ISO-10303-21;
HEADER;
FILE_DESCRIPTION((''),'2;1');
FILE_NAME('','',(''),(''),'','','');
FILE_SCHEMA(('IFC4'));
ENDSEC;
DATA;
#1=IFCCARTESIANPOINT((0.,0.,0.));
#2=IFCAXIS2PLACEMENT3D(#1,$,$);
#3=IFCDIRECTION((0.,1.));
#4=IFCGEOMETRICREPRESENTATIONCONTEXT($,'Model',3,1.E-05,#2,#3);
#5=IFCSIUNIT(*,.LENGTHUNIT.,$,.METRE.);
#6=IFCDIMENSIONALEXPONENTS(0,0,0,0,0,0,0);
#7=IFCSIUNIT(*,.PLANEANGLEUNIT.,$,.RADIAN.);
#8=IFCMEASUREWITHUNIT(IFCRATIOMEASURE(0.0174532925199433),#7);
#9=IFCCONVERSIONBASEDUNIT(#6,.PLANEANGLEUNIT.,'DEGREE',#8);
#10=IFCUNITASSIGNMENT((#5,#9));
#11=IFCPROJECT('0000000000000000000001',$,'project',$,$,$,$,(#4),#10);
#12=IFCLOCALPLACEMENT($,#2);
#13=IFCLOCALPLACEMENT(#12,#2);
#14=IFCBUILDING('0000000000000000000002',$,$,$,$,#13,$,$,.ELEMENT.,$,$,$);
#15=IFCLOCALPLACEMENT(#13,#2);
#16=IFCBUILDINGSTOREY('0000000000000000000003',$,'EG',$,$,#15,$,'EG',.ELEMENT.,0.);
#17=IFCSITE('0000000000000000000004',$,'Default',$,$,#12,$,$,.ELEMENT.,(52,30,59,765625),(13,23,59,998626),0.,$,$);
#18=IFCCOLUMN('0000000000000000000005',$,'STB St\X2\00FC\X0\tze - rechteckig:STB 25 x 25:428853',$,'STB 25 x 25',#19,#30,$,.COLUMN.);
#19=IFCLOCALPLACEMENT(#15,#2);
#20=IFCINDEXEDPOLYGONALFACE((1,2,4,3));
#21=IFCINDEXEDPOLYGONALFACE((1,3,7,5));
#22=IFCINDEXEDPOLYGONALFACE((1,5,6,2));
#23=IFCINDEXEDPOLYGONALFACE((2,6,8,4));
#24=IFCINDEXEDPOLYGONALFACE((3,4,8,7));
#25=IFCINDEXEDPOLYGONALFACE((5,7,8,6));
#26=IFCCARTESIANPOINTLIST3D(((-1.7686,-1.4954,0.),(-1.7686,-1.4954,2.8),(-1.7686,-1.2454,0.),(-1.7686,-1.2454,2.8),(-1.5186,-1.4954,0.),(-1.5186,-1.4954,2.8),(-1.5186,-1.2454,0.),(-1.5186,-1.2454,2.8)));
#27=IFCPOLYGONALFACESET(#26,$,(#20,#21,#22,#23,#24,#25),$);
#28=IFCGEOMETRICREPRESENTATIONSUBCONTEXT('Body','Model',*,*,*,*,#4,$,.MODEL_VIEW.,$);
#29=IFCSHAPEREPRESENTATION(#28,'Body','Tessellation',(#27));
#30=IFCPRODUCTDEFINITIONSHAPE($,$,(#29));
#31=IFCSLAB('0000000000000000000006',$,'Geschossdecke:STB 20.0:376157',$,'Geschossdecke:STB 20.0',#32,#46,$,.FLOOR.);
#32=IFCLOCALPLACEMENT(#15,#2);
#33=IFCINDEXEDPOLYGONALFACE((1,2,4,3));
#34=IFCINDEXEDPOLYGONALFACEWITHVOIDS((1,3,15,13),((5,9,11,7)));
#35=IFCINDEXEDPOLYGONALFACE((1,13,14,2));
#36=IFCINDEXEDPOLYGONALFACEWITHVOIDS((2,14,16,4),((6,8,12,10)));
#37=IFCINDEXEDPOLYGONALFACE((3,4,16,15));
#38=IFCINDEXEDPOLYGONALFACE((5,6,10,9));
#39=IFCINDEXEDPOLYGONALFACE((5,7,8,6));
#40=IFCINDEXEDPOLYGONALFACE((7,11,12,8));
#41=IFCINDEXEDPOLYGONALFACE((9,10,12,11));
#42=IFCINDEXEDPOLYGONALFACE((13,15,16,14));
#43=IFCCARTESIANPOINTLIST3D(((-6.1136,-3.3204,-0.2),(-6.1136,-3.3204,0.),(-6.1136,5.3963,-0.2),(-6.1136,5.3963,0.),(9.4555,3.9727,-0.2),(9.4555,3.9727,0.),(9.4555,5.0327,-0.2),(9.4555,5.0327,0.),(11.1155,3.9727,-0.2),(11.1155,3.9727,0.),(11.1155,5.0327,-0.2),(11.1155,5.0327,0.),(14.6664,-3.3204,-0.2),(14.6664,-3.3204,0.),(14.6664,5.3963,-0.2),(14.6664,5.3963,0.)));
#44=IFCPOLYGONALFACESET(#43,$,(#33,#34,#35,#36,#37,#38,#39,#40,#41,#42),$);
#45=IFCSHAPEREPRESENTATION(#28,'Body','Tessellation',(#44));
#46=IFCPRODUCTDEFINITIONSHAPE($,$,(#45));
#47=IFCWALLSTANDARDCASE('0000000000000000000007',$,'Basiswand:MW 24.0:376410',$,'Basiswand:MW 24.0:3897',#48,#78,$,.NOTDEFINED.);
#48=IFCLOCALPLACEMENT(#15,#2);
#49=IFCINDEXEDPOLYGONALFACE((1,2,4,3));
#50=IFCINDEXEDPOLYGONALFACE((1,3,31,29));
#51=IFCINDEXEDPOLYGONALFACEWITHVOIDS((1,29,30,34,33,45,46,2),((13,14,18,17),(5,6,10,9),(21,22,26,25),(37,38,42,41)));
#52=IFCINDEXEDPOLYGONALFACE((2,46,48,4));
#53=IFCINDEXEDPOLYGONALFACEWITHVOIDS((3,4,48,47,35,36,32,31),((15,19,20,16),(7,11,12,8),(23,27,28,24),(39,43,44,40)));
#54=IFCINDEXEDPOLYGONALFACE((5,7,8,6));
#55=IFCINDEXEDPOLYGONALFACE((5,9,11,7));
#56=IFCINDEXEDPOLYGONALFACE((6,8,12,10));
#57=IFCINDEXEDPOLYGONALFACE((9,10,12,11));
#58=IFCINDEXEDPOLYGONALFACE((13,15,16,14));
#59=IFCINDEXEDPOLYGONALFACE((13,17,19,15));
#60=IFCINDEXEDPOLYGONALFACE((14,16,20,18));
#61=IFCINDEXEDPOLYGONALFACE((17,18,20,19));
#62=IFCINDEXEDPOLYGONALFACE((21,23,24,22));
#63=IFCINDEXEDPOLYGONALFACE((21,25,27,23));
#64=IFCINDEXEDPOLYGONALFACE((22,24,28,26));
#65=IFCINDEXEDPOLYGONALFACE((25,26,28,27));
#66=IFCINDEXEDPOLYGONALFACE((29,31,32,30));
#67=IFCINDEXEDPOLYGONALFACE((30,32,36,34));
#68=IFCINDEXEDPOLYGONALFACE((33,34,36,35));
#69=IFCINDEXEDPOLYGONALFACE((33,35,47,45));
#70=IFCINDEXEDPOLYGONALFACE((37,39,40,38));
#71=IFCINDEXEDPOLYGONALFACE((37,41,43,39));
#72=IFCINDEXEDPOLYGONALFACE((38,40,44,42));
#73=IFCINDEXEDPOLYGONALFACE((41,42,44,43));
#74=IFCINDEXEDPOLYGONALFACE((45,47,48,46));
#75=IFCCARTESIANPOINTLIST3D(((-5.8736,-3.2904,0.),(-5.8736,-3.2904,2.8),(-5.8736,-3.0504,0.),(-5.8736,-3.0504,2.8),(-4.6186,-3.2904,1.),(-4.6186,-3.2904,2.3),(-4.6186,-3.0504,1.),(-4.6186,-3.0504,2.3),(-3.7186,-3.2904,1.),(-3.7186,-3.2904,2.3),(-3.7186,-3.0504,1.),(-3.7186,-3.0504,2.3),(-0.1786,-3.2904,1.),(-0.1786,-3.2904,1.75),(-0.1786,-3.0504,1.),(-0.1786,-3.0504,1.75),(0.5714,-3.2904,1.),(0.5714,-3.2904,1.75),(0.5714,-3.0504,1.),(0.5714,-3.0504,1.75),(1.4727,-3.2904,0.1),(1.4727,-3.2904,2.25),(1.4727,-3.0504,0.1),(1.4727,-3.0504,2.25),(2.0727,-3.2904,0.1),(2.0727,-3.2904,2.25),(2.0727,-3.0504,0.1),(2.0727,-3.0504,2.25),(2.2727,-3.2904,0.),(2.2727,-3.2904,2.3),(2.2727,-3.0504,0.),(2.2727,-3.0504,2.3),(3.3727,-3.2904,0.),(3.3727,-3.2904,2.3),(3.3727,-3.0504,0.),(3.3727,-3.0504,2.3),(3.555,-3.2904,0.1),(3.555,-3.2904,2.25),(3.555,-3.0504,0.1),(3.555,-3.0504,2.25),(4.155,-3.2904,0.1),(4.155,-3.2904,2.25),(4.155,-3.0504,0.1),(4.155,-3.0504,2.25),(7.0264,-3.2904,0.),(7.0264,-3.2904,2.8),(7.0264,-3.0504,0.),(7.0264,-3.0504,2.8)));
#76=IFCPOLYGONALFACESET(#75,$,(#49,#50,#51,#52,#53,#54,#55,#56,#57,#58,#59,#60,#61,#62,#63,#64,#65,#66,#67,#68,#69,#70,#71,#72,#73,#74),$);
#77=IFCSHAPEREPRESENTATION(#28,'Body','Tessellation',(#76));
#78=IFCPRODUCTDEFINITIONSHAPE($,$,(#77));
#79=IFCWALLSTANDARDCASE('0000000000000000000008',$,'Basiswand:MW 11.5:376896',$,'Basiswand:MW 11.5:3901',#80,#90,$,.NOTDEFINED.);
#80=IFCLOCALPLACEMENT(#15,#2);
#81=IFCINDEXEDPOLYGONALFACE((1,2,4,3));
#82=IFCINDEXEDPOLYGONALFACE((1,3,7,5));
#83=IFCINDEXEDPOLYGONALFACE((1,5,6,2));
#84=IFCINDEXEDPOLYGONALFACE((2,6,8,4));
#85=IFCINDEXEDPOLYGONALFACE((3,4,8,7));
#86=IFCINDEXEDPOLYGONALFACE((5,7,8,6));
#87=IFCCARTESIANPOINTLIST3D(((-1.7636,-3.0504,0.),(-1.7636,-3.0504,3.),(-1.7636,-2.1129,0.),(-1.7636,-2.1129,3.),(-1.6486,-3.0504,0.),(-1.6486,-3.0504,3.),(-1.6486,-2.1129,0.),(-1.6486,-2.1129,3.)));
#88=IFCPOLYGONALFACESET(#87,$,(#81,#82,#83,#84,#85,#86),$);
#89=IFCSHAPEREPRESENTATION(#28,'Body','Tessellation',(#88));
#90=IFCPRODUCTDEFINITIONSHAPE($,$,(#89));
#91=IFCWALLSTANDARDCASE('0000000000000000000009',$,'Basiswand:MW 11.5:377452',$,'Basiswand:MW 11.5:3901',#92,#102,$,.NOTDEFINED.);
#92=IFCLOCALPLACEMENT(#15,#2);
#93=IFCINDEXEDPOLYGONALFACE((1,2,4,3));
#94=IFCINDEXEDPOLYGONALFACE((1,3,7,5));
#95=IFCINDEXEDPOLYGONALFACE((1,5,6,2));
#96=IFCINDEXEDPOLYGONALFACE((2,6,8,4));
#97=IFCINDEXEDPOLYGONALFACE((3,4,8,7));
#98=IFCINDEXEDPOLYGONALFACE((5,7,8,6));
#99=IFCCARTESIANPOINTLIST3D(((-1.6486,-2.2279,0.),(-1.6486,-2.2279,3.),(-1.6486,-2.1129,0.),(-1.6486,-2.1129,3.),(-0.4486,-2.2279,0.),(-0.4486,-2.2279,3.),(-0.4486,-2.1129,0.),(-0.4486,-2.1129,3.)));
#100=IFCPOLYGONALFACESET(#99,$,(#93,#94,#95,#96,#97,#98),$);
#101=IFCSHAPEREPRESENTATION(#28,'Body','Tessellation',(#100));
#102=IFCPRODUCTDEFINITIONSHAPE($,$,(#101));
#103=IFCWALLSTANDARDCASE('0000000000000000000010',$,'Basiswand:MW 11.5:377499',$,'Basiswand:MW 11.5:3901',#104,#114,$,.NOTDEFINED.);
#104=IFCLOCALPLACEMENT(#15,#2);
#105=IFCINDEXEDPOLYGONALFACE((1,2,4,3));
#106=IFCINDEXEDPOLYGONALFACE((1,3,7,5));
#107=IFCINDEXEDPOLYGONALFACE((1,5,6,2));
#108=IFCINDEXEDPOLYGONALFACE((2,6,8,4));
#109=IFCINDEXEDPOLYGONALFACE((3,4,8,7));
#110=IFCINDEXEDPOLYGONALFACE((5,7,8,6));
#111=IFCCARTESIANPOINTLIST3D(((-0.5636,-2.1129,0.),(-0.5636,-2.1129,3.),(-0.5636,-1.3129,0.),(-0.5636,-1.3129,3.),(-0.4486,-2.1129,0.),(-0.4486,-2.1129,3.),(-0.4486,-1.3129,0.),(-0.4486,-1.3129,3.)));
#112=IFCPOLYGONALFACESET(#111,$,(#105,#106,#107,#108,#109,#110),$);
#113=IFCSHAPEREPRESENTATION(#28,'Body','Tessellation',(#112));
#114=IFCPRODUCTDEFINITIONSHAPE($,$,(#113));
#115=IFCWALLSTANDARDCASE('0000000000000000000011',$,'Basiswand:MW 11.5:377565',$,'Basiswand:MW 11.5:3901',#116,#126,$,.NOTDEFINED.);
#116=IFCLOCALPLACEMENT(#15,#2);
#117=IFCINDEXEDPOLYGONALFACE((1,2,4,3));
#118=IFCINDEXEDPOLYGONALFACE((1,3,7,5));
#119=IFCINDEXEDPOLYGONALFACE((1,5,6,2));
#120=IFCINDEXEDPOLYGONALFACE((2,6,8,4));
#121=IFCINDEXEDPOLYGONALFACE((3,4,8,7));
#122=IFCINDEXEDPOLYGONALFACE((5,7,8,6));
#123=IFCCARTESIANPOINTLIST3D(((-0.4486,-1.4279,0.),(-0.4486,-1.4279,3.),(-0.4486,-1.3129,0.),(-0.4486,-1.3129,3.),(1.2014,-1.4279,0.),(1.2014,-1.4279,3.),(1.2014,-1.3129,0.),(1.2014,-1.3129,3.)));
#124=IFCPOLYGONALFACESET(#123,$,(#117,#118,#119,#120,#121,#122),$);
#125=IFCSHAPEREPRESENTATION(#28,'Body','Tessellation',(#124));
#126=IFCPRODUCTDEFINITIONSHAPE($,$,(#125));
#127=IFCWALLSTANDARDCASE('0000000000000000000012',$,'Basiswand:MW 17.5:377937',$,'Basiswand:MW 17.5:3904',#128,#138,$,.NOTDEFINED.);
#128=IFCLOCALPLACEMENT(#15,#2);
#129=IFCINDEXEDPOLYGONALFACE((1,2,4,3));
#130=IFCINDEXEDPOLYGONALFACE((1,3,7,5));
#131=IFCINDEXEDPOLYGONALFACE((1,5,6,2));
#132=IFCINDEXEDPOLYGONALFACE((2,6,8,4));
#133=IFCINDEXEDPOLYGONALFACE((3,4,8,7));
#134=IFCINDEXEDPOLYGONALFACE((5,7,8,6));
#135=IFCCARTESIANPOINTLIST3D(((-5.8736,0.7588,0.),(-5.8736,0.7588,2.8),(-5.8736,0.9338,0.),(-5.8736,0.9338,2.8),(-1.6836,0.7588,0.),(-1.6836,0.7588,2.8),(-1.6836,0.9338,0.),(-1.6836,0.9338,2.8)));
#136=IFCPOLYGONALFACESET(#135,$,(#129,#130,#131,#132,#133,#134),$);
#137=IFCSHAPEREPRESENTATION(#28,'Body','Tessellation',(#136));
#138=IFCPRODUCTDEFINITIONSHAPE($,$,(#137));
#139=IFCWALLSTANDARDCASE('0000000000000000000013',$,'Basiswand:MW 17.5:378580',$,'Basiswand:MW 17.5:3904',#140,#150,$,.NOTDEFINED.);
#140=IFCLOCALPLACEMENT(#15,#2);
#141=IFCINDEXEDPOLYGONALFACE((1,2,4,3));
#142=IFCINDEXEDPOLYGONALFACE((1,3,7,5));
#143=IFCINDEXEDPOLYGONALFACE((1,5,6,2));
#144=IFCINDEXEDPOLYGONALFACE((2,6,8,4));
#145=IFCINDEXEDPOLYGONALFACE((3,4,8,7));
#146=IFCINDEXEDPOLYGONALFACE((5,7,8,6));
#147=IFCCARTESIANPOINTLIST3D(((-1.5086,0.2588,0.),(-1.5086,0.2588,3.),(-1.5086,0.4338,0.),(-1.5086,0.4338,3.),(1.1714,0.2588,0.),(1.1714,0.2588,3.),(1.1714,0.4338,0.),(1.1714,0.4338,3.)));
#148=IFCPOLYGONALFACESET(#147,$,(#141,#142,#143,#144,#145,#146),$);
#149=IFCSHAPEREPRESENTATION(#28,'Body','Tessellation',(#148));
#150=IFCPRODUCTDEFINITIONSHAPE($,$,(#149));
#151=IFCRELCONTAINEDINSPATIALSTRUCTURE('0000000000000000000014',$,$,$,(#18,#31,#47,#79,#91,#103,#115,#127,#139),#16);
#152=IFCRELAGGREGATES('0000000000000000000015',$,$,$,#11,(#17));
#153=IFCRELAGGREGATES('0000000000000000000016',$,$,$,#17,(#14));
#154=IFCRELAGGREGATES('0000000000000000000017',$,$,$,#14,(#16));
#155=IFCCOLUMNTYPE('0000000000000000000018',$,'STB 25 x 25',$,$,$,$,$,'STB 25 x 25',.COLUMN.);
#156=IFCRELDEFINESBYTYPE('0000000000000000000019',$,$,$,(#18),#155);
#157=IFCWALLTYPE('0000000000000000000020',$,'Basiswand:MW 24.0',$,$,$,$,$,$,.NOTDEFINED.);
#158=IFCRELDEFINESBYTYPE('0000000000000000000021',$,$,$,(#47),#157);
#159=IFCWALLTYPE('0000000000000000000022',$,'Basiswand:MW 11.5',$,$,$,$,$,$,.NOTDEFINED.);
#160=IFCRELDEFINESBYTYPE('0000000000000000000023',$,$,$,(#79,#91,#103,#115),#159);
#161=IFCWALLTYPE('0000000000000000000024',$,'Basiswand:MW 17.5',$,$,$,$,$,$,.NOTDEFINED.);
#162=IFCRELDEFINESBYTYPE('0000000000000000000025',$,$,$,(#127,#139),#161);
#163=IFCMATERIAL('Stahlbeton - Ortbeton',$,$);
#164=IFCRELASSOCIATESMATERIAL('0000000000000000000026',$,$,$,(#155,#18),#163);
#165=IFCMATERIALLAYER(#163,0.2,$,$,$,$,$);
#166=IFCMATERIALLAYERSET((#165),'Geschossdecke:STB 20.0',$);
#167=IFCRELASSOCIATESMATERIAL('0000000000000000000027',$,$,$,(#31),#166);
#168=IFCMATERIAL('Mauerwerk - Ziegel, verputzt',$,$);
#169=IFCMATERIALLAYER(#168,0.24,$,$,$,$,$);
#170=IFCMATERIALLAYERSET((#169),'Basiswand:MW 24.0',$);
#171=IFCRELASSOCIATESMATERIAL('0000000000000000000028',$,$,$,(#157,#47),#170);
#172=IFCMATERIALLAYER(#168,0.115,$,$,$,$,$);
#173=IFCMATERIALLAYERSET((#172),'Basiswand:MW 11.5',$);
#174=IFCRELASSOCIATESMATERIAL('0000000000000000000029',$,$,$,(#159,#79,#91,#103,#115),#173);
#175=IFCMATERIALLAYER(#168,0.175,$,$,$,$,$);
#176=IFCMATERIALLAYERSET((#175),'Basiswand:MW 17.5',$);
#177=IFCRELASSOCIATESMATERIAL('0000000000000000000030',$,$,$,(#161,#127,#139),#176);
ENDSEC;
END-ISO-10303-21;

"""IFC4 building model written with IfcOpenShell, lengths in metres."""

from ifc_helpers import new_model, entity, si_unit, converted_unit, direction, frame, frame_2d, origin, place, context, subcontext, project, spatial, polyline, rectangle, extrude, clip, bounded_halfspace, source, transform, mapped, material, layer, layer_set, layer_usage, type_object, type_shapes, element, save


model = new_model("IFC4")

# Units and contexts
model_context = context("Model", 3, precision=1e-05, world=origin(), true_north=direction((0.0, 1.0)))
body_context = subcontext(model_context, "Body", "Model", "MODEL_VIEW")
ifc_project = project(units=[si_unit("LENGTHUNIT", "METRE"), converted_unit("PLANEANGLEUNIT", "DEGREE", entity("IfcRatioMeasure", 0.0174532925199433), si_unit("PLANEANGLEUNIT", "RADIAN"), dimensions=[0, 0, 0, 0, 0, 0, 0])], contexts=[model_context])

# Site, building, storey
site_placement = place(None, origin())
site = spatial("IfcSite", under=ifc_project, at=site_placement, Name="Default", CompositionType="ELEMENT", RefLatitude=(52, 30, 59, 765625), RefLongitude=(13, 23, 59, 998626), RefElevation=0.0)
building_placement = place(site_placement, origin())
building = spatial("IfcBuilding", under=site, at=building_placement, CompositionType="ELEMENT")
storey_placement = place(building_placement, origin())
storey = spatial("IfcBuildingStorey", under=building, at=storey_placement, Name="EG", LongName="EG", CompositionType="ELEMENT", Elevation=0.0)

# Column
ifc_material_1 = material(Name="Stahlbeton - Ortbeton")
column_type = type_object("IfcColumnType", Name="STB 25 x 25", ElementType="STB 25 x 25", PredefinedType="COLUMN", material=ifc_material_1)
shared_shape = source(origin(), body_context, "Body", "SweptSolid", [
    extrude(rectangle(XDim=0.25, YDim=0.25, at=frame_2d((0.0, 0.0), x_axis=(1.0, 0.0))), frame((-1.6436, -1.3704, 0.0), z_axis=(0.0, 0.0, 1.0), x_axis=(0.0, -1.0, 0.0)), (0.0, 0.0, 1.0), 2.8),
])
type_shapes(column_type, [shared_shape])
column_placement = place(storey_placement, origin())
element("IfcColumn", 1, at=column_placement, inside=storey, type_object=column_type, material=ifc_material_1, Name="STB Stütze - rechteckig:STB 25 x 25:428853", ObjectType="STB 25 x 25", PredefinedType="COLUMN", context=body_context, shape_type="MappedRepresentation", body=[
    mapped(shared_shape, transform((0.0, 0.0, 0.0), scale=1.0)),
])

# Slab, opening
ifc_layer_1 = layer(ifc_material_1, 0.2)
ifc_layer_set_1 = layer_set([ifc_layer_1], Name="Geschossdecke:STB 20.0")
ifc_layer_usage_1 = layer_usage(ifc_layer_set_1, "AXIS3", "POSITIVE", 0.0)
slab_placement = place(storey_placement, origin())
slab = element("IfcSlab", 2, at=slab_placement, inside=storey, material=ifc_layer_usage_1, Name="Geschossdecke:STB 20.0:376157", ObjectType="Geschossdecke:STB 20.0", PredefinedType="FLOOR", context=body_context, shape_type="SweptSolid", body=[
    extrude(rectangle(XDim=8.7167, YDim=20.78, at=frame_2d((0.0, 0.0), x_axis=(0.0, -1.0))), frame((4.2764, 1.038, 0.0), z_axis=(0.0, 0.0, -1.0), x_axis=(-1.0, 0.0, 0.0)), (0.0, 0.0, 1.0), 0.2),
])
opening_1_placement = place(storey_placement, origin())
element("IfcOpeningElement", 3, at=opening_1_placement, cuts=slab, ObjectType="Opening", context=body_context, shape_type="SweptSolid", body=[
    extrude(rectangle(XDim=1.06, YDim=1.66, at=frame_2d((-6.0091, 3.4647), x_axis=(0.0, -1.0))), frame((4.2764, 1.038, 0.0), z_axis=(0.0, 0.0, -1.0), x_axis=(-1.0, 0.0, 0.0)), (0.0, 0.0, 1.0), 0.2),
])

# Wall, openings
ifc_material_2 = material(Name="Mauerwerk - Ziegel, verputzt")
ifc_layer_2 = layer(ifc_material_2, 0.24)
ifc_layer_set_2 = layer_set([ifc_layer_2], Name="Basiswand:MW 24.0")
ifc_layer_usage_2 = layer_usage(ifc_layer_set_2, "AXIS2", "NEGATIVE", 0.12)
wall_type_1 = type_object("IfcWallType", Name="Basiswand:MW 24.0", PredefinedType="NOTDEFINED", material=ifc_layer_set_2)
wall_1_placement = place(storey_placement, frame((-5.8736, -3.1704, 0.0)))
wall_1 = element("IfcWallStandardCase", 4, at=wall_1_placement, inside=storey, type_object=wall_type_1, material=ifc_layer_usage_2, Name="Basiswand:MW 24.0:376410", ObjectType="Basiswand:MW 24.0:3897", PredefinedType="NOTDEFINED", context=body_context, shape_type="Clipping", body=[
    clip(extrude(rectangle(XDim=12.9, YDim=0.24, at=frame_2d((6.45, 0.0), x_axis=(-1.0, 0.0))), origin(), (0.0, 0.0, 1.0), 2.8), bounded_halfspace(frame((0.0, -0.12, 2.8), z_axis=(0.0, 0.0, -1.0), x_axis=(0.0, -1.0, 0.0)), True, frame((0.0, -0.12, 2.8)), polyline([(0.0, 0.0), (12.9, 0.0), (12.9, 0.24), (0.0, 0.24), (0.0, 0.0)]))),
])
opening_2_placement = place(wall_1_placement, frame((8.1462, -0.12, 0.0)))
element("IfcOpeningElement", 5, at=opening_2_placement, cuts=wall_1, ObjectType="Opening", PredefinedType="OPENING", context=body_context, shape_type="SweptSolid", body=[
    extrude(rectangle(XDim=2.3, YDim=1.1, at=frame_2d((1.15, 0.55), x_axis=(1.0, 0.0))), frame((0.0, 0.0, 0.0), z_axis=(0.0, 1.0, 0.0), x_axis=(0.0, 0.0, 1.0)), (0.0, 0.0, 1.0), 0.24),
])
opening_3_placement = place(wall_1_placement, frame((7.3462, -0.12, 0.1)))
element("IfcOpeningElement", 6, at=opening_3_placement, cuts=wall_1, ObjectType="Opening", PredefinedType="OPENING", context=body_context, shape_type="SweptSolid", body=[
    extrude(rectangle(XDim=2.15, YDim=0.6, at=frame_2d((1.075, 0.3), x_axis=(1.0, 0.0))), frame((0.0, 0.0, 0.0), z_axis=(0.0, 1.0, 0.0), x_axis=(0.0, 0.0, 1.0)), (0.0, 0.0, 1.0), 0.24),
])
opening_4_placement = place(wall_1_placement, frame((5.695, -0.12, 1.0)))
element("IfcOpeningElement", 7, at=opening_4_placement, cuts=wall_1, ObjectType="Opening", PredefinedType="OPENING", context=body_context, shape_type="SweptSolid", body=[
    extrude(rectangle(XDim=0.75, YDim=0.75, at=frame_2d((0.375, 0.375), x_axis=(1.0, 0.0))), frame((0.0, 0.0, 0.0), z_axis=(0.0, 1.0, 0.0), x_axis=(0.0, 0.0, 1.0)), (0.0, 0.0, 1.0), 0.24),
])
opening_5_placement = place(wall_1_placement, frame((1.255, -0.12, 1.0)))
element("IfcOpeningElement", 8, at=opening_5_placement, cuts=wall_1, ObjectType="Opening", PredefinedType="OPENING", context=body_context, shape_type="SweptSolid", body=[
    extrude(rectangle(XDim=1.3, YDim=0.9, at=frame_2d((0.65, 0.45), x_axis=(1.0, 0.0))), frame((0.0, 0.0, 0.0), z_axis=(0.0, 1.0, 0.0), x_axis=(0.0, 0.0, 1.0)), (0.0, 0.0, 1.0), 0.24),
])
opening_6_placement = place(wall_1_placement, frame((9.4286, -0.12, 0.1)))
element("IfcOpeningElement", 9, at=opening_6_placement, cuts=wall_1, ObjectType="Opening", PredefinedType="OPENING", context=body_context, shape_type="SweptSolid", body=[
    extrude(rectangle(XDim=2.15, YDim=0.6, at=frame_2d((1.075, 0.3), x_axis=(1.0, 0.0))), frame((0.0, 0.0, 0.0), z_axis=(0.0, 1.0, 0.0), x_axis=(0.0, 0.0, 1.0)), (0.0, 0.0, 1.0), 0.24),
])

# Walls
ifc_layer_3 = layer(ifc_material_2, 0.115)
ifc_layer_set_3 = layer_set([ifc_layer_3], Name="Basiswand:MW 11.5")
ifc_layer_usage_3 = layer_usage(ifc_layer_set_3, "AXIS2", "NEGATIVE", 0.0575)
wall_type_2 = type_object("IfcWallType", Name="Basiswand:MW 11.5", PredefinedType="NOTDEFINED", material=ifc_layer_set_3)
wall_2_placement = place(storey_placement, frame((-1.7061, -3.0504, 0.0), z_axis=(0.0, 0.0, 1.0), x_axis=(0.0, 1.0, 0.0)))
element("IfcWallStandardCase", 10, at=wall_2_placement, inside=storey, type_object=wall_type_2, material=ifc_layer_usage_3, Name="Basiswand:MW 11.5:376896", ObjectType="Basiswand:MW 11.5:3901", PredefinedType="NOTDEFINED", context=body_context, shape_type="SweptSolid", body=[
    extrude(rectangle(XDim=0.9375, YDim=0.115, at=frame_2d((0.4688, 0.0), x_axis=(-1.0, 0.0))), origin(), (0.0, 0.0, 1.0), 3.0),
])
ifc_layer_usage_4 = layer_usage(ifc_layer_set_3, "AXIS2", "NEGATIVE", 0.0575)
wall_3_placement = place(storey_placement, frame((-1.6486, -2.1704, 0.0)))
element("IfcWallStandardCase", 11, at=wall_3_placement, inside=storey, type_object=wall_type_2, material=ifc_layer_usage_4, Name="Basiswand:MW 11.5:377452", ObjectType="Basiswand:MW 11.5:3901", PredefinedType="NOTDEFINED", context=body_context, shape_type="SweptSolid", body=[
    extrude(rectangle(XDim=1.2, YDim=0.115, at=frame_2d((0.6, 0.0), x_axis=(-1.0, 0.0))), origin(), (0.0, 0.0, 1.0), 3.0),
])
ifc_layer_usage_5 = layer_usage(ifc_layer_set_3, "AXIS2", "NEGATIVE", 0.0575)
wall_4_placement = place(storey_placement, frame((-0.5061, -2.1129, 0.0), z_axis=(0.0, 0.0, 1.0), x_axis=(0.0, 1.0, 0.0)))
element("IfcWallStandardCase", 12, at=wall_4_placement, inside=storey, type_object=wall_type_2, material=ifc_layer_usage_5, Name="Basiswand:MW 11.5:377499", ObjectType="Basiswand:MW 11.5:3901", PredefinedType="NOTDEFINED", context=body_context, shape_type="SweptSolid", body=[
    extrude(rectangle(XDim=0.8, YDim=0.115, at=frame_2d((0.4, 0.0), x_axis=(-1.0, 0.0))), origin(), (0.0, 0.0, 1.0), 3.0),
])
ifc_layer_usage_6 = layer_usage(ifc_layer_set_3, "AXIS2", "NEGATIVE", 0.0575)
wall_5_placement = place(storey_placement, frame((-0.4486, -1.3704, 0.0)))
element("IfcWallStandardCase", 13, at=wall_5_placement, inside=storey, type_object=wall_type_2, material=ifc_layer_usage_6, Name="Basiswand:MW 11.5:377565", ObjectType="Basiswand:MW 11.5:3901", PredefinedType="NOTDEFINED", context=body_context, shape_type="SweptSolid", body=[
    extrude(rectangle(XDim=1.65, YDim=0.115, at=frame_2d((0.825, 0.0), x_axis=(-1.0, 0.0))), origin(), (0.0, 0.0, 1.0), 3.0),
])
ifc_layer_4 = layer(ifc_material_2, 0.175)
ifc_layer_set_4 = layer_set([ifc_layer_4], Name="Basiswand:MW 17.5")
ifc_layer_usage_7 = layer_usage(ifc_layer_set_4, "AXIS2", "NEGATIVE", 0.0875)
wall_type_3 = type_object("IfcWallType", Name="Basiswand:MW 17.5", PredefinedType="NOTDEFINED", material=ifc_layer_set_4)
wall_6_placement = place(storey_placement, frame((-5.8736, 0.8463, 0.0)))
element("IfcWallStandardCase", 14, at=wall_6_placement, inside=storey, type_object=wall_type_3, material=ifc_layer_usage_7, Name="Basiswand:MW 17.5:377937", ObjectType="Basiswand:MW 17.5:3904", PredefinedType="NOTDEFINED", context=body_context, shape_type="Clipping", body=[
    clip(extrude(rectangle(XDim=4.19, YDim=0.175, at=frame_2d((2.095, 0.0), x_axis=(-1.0, 0.0))), origin(), (0.0, 0.0, 1.0), 2.8), bounded_halfspace(frame((0.0, -0.0875, 2.8), z_axis=(0.0, 0.0, -1.0), x_axis=(0.0, -1.0, 0.0)), True, frame((0.0, -0.0875, 2.8)), polyline([(0.0, 0.0), (4.19, 0.0), (4.19, 0.175), (0.0, 0.175), (0.0, 0.0)]))),
])
ifc_layer_usage_8 = layer_usage(ifc_layer_set_4, "AXIS2", "NEGATIVE", 0.0875)
wall_7_placement = place(storey_placement, frame((-1.5086, 0.3463, 0.0)))
element("IfcWallStandardCase", 15, at=wall_7_placement, inside=storey, type_object=wall_type_3, material=ifc_layer_usage_8, Name="Basiswand:MW 17.5:378580", ObjectType="Basiswand:MW 17.5:3904", PredefinedType="NOTDEFINED", context=body_context, shape_type="SweptSolid", body=[
    extrude(rectangle(XDim=2.68, YDim=0.175, at=frame_2d((1.34, 0.0), x_axis=(-1.0, 0.0))), origin(), (0.0, 0.0, 1.0), 3.0),
])

save(model, "model.ifc")
